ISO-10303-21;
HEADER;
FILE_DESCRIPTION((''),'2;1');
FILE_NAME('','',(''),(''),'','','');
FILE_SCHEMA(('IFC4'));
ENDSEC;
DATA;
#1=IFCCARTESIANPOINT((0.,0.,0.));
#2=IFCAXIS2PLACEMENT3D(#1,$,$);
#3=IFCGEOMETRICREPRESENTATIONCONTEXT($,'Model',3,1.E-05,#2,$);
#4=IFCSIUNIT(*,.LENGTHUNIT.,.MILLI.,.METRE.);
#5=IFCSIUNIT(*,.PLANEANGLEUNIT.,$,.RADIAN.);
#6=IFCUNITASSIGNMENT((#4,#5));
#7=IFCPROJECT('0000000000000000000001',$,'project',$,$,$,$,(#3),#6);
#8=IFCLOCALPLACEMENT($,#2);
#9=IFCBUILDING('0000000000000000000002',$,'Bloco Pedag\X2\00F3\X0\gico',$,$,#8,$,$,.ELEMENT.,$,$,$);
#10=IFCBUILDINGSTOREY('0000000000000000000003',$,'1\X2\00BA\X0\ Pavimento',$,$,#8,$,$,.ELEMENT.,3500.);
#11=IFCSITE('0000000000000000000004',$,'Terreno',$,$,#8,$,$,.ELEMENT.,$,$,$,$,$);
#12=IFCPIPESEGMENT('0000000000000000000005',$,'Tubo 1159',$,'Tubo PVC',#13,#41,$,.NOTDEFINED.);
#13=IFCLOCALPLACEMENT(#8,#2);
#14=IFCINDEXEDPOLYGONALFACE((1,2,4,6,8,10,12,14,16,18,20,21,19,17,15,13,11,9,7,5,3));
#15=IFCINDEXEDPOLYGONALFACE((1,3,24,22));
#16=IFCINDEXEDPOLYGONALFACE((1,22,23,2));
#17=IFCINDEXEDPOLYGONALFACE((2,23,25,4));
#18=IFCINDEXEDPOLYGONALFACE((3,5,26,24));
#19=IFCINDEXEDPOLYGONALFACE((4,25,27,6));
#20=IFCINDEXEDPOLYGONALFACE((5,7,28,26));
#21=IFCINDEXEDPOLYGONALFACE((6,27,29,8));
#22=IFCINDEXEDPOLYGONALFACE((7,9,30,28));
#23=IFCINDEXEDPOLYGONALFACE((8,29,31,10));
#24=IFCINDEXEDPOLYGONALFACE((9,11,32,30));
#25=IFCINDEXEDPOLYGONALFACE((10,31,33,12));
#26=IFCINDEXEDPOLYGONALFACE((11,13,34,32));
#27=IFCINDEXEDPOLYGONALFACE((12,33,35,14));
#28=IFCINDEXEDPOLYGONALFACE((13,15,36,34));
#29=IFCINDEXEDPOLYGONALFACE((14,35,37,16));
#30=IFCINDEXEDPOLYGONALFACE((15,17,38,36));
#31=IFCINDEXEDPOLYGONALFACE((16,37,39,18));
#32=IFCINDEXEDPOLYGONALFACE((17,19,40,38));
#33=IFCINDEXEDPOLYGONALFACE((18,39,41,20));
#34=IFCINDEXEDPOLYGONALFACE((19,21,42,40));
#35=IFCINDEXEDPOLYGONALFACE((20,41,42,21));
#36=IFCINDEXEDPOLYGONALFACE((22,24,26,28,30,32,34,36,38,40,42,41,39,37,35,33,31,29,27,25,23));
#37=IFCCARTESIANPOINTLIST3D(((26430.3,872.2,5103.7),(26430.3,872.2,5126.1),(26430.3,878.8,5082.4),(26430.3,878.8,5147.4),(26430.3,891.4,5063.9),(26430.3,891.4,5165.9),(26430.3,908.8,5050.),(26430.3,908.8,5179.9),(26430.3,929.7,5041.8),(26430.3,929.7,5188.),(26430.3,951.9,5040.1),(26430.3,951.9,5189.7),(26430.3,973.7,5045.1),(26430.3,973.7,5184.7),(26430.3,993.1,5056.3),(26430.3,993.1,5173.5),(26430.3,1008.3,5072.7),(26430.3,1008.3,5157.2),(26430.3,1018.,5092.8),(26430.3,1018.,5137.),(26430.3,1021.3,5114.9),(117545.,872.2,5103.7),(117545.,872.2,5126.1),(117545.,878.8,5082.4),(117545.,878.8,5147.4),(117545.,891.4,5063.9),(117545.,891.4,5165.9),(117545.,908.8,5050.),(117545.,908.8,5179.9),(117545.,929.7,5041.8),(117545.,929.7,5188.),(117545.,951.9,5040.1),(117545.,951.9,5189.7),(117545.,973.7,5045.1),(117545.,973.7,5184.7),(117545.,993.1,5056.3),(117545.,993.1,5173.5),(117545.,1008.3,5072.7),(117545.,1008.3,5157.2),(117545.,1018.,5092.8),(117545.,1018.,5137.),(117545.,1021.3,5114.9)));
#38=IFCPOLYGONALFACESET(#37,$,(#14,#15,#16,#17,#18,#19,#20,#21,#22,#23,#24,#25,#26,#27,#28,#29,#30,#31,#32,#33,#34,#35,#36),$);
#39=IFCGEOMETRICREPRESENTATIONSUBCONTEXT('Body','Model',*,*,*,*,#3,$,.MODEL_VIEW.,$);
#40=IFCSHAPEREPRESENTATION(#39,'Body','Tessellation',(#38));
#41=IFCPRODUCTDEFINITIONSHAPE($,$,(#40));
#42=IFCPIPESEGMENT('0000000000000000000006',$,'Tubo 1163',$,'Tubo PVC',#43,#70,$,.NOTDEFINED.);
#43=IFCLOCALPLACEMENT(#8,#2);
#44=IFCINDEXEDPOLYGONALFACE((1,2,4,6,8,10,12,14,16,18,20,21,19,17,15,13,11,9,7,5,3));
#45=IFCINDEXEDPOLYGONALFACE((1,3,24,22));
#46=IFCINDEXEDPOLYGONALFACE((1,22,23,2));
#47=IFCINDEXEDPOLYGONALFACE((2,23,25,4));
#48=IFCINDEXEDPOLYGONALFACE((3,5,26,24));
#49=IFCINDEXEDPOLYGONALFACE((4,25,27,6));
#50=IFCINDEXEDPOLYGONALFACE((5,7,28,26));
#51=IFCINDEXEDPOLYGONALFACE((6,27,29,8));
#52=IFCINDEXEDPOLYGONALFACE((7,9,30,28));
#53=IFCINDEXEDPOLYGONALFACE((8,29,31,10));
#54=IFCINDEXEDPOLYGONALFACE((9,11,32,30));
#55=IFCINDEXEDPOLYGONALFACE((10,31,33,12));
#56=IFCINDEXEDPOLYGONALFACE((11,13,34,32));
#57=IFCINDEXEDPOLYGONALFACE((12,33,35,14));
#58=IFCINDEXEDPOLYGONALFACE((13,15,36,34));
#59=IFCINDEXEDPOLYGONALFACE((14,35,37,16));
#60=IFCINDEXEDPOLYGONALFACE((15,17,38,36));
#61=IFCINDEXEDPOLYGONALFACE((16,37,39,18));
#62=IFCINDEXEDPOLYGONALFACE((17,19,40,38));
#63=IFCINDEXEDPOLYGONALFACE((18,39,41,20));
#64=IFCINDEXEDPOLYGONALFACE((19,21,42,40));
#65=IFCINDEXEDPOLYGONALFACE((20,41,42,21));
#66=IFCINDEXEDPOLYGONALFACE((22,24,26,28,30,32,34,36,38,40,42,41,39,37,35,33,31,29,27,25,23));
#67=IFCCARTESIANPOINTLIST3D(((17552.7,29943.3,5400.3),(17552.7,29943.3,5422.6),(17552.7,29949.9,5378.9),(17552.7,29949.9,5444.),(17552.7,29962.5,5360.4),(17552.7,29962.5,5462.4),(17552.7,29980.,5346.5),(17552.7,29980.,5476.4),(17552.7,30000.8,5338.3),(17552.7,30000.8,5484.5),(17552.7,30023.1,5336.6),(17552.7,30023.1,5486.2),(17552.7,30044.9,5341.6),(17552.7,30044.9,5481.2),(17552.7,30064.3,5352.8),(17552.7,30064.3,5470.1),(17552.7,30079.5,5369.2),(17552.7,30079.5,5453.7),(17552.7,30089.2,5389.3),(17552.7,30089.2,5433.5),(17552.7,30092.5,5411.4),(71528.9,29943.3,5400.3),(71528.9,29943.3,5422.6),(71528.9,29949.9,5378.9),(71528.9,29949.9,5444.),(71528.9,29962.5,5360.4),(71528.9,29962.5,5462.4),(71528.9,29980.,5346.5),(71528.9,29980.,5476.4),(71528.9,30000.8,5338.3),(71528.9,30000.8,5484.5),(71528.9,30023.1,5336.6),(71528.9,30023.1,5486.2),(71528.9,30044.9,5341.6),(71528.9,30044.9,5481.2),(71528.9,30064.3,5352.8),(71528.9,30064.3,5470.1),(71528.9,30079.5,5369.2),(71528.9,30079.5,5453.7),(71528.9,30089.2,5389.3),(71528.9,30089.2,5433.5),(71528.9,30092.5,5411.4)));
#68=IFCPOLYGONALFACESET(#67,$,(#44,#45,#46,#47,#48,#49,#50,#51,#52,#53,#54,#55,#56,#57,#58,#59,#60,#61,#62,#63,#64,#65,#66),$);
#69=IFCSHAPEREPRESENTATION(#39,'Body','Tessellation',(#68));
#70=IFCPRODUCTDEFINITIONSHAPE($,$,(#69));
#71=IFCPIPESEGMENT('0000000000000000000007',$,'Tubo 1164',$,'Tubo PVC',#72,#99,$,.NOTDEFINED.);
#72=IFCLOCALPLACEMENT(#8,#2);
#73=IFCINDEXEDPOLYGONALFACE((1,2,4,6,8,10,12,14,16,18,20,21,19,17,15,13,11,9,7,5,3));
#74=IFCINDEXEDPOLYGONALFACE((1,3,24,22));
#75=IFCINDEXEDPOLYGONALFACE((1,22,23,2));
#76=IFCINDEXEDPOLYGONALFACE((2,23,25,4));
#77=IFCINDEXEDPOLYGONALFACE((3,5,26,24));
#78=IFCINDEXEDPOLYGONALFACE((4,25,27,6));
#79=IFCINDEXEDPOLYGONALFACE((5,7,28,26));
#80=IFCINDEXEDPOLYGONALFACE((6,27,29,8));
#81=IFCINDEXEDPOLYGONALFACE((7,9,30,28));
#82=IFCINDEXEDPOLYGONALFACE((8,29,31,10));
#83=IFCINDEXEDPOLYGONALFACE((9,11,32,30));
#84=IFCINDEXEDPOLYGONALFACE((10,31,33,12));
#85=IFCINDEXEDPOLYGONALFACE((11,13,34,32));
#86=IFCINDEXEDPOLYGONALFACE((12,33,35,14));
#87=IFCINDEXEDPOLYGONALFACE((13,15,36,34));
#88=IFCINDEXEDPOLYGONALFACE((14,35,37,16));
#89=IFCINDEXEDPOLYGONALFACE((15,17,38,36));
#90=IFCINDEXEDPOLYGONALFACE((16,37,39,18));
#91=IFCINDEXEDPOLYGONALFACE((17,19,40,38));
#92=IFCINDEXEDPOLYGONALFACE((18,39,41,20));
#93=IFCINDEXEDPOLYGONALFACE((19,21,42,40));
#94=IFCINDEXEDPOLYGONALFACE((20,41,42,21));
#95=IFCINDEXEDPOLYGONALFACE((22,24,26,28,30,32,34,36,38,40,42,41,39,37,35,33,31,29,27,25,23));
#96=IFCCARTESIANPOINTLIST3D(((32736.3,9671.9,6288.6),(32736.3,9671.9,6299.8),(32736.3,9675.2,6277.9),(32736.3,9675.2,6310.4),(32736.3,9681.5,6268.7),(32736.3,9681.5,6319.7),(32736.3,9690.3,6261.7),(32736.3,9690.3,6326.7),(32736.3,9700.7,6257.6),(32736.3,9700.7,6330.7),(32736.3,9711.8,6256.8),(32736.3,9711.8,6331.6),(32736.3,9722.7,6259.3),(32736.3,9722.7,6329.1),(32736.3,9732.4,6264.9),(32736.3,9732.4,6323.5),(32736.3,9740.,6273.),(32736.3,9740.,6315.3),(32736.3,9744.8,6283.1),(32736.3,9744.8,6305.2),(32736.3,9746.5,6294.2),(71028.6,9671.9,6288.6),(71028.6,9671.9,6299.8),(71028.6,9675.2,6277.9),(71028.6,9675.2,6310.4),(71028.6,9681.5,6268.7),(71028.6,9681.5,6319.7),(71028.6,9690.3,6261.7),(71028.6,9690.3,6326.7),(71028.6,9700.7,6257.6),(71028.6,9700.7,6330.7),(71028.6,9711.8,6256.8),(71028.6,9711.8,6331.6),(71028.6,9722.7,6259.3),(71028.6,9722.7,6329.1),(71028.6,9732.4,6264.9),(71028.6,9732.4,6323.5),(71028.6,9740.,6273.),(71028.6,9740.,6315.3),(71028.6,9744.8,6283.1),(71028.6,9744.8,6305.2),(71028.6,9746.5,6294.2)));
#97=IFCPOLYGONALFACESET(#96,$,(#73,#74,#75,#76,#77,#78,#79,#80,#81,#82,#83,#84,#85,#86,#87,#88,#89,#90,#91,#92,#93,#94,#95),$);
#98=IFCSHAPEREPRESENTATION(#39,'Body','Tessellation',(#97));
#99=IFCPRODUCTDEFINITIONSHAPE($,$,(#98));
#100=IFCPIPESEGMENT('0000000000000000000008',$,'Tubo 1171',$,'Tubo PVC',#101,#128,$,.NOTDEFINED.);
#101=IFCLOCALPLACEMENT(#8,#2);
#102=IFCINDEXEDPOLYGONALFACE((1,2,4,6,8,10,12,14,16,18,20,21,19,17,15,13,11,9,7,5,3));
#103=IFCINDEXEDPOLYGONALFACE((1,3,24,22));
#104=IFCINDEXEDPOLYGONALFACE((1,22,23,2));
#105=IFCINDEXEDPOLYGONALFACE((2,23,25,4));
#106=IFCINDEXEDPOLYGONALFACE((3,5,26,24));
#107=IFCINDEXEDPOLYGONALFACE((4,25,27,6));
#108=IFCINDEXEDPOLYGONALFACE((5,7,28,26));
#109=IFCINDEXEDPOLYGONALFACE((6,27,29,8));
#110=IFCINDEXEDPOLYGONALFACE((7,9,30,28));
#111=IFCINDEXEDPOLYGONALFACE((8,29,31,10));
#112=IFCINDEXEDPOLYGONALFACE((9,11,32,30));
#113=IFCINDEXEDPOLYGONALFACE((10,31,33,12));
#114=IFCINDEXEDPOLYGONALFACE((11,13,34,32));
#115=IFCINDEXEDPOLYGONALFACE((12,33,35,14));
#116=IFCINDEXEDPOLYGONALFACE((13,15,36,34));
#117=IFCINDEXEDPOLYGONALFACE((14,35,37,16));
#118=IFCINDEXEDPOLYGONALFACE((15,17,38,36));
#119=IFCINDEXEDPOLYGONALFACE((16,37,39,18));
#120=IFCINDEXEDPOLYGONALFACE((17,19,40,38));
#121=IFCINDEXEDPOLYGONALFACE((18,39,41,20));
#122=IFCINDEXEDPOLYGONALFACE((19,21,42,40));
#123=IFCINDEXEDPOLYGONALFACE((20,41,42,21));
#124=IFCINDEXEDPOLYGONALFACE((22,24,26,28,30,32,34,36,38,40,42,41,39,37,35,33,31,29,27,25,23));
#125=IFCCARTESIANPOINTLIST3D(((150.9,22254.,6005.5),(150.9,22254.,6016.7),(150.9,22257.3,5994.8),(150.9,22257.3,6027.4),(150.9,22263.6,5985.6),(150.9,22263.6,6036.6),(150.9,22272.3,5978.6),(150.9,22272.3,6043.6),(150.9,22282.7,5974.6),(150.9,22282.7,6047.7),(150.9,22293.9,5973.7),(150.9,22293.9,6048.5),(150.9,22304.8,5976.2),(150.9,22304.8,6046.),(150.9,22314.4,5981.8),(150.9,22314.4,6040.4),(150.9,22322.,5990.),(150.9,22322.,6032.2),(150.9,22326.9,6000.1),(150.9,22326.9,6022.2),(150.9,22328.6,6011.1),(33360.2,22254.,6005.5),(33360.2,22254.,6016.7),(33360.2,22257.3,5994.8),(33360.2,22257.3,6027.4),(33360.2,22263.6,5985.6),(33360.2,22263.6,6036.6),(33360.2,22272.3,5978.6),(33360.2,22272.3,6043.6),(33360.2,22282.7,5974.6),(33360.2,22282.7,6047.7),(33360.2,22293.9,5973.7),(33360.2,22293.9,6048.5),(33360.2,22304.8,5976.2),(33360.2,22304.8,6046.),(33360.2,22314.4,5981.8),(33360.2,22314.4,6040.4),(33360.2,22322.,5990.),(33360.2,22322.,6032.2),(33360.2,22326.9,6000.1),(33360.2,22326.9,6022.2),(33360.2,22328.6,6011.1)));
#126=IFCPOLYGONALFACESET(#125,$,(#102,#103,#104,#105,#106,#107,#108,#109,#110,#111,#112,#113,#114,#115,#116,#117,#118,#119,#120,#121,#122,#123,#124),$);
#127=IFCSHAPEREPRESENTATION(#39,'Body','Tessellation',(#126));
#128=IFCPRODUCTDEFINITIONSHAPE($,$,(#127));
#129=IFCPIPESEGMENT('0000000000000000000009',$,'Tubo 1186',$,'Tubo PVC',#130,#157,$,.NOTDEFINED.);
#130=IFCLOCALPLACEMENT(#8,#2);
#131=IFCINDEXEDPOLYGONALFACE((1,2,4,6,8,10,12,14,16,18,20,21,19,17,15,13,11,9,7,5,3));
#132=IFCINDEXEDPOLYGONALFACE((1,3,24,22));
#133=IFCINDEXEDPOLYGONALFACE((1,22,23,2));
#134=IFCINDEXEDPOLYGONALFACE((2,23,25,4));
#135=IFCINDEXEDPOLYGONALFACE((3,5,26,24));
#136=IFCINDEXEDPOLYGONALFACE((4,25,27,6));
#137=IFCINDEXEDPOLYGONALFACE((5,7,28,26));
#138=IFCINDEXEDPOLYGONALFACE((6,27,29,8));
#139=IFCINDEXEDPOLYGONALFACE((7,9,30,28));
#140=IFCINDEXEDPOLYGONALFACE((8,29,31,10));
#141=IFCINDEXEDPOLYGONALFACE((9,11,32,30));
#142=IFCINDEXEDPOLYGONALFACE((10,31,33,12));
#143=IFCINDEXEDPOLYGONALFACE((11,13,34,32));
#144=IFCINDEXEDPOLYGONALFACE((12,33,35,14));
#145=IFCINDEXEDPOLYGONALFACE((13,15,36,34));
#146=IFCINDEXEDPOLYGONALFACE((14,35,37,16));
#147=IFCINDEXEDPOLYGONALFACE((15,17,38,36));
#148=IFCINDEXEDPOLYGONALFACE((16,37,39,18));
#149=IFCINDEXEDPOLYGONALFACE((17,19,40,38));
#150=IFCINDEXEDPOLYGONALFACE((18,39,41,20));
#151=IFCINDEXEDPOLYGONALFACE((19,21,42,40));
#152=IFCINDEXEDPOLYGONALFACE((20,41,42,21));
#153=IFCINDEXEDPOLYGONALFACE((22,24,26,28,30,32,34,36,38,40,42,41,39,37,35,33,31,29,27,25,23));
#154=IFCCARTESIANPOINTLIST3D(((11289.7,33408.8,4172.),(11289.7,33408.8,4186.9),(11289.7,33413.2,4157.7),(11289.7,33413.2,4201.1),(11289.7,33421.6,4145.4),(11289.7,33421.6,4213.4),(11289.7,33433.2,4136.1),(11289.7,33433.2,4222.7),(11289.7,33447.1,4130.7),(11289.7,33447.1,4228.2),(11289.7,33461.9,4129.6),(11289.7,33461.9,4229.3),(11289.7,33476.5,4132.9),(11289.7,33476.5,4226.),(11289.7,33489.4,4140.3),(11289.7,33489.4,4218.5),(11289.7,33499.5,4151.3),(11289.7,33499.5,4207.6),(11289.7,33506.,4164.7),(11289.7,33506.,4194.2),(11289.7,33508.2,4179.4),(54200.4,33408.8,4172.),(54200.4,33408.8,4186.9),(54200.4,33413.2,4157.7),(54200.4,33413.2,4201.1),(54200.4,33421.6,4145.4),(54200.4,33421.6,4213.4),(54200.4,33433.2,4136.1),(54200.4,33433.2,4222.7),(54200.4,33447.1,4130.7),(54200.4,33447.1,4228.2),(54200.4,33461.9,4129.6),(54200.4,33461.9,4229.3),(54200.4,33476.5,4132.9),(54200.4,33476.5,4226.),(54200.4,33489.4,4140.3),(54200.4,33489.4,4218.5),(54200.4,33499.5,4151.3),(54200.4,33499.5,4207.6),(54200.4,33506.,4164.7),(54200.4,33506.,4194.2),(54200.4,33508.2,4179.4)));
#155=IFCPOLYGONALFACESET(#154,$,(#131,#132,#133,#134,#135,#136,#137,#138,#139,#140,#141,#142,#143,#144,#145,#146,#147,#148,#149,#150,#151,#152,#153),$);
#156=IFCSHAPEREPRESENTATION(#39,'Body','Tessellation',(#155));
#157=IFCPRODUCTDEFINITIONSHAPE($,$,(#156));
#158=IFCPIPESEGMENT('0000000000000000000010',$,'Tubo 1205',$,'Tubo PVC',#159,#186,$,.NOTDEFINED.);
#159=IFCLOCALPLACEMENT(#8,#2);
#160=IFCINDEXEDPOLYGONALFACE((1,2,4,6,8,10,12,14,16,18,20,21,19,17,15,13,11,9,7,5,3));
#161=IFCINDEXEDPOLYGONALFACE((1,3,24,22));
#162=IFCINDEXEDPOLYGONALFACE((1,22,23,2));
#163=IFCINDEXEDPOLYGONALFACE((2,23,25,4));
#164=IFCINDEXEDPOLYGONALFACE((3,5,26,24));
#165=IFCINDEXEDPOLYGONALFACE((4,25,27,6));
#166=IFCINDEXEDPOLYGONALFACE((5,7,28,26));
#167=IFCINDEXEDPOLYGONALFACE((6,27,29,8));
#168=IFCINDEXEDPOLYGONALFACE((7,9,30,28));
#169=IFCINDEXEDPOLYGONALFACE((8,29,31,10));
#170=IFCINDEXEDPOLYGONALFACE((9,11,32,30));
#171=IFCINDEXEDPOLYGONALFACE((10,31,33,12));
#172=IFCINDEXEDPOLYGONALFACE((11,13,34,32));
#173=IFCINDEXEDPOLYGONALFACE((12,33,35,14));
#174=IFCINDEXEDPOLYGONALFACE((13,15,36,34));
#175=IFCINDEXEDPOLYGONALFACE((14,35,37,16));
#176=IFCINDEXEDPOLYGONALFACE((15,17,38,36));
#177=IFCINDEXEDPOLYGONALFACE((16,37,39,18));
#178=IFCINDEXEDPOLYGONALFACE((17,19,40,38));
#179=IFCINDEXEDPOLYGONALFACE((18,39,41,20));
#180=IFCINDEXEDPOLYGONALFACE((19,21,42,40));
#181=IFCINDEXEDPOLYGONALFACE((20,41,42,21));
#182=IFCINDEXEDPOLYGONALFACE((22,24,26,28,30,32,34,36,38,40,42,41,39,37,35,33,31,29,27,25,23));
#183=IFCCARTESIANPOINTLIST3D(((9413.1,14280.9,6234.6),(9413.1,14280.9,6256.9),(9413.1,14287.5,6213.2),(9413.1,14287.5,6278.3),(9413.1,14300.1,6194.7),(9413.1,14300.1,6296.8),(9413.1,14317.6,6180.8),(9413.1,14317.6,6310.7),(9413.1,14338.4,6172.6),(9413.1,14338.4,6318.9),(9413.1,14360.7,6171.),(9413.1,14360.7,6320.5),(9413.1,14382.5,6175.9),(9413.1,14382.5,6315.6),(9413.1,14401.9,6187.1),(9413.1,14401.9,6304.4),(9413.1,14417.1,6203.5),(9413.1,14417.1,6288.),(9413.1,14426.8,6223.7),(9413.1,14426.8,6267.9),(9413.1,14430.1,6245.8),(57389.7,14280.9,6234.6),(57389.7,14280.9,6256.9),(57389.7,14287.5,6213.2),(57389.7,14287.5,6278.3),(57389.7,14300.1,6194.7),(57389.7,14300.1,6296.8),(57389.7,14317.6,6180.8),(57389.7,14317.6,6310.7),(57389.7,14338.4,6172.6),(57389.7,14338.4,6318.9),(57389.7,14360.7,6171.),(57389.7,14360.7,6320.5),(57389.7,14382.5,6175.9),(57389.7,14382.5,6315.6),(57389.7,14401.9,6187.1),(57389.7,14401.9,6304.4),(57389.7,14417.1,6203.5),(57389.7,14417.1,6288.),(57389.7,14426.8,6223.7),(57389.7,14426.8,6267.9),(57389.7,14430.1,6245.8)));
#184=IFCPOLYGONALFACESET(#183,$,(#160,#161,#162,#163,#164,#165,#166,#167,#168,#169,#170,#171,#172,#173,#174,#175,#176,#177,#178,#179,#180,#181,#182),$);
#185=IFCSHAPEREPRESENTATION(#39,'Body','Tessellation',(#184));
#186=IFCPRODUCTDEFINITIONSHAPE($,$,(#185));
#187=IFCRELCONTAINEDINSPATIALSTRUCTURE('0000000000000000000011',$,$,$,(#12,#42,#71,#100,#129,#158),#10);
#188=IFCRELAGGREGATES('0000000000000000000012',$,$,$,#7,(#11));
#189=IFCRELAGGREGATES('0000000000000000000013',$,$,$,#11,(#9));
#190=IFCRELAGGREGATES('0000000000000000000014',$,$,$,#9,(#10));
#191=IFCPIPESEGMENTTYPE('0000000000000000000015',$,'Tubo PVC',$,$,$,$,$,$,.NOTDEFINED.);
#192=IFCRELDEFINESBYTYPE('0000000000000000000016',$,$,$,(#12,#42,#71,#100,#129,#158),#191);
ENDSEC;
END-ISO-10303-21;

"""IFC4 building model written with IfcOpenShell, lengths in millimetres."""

from ifc_helpers import new_model, si_unit, frame, origin, origin_2d, place, context, subcontext, project, spatial, circle, extrude, type_object, element, save


model = new_model("IFC4")

# Units and contexts
model_context = context("Model", 3, precision=1e-05, world=origin())
body_context = subcontext(model_context, "Body", "Model", "MODEL_VIEW")
ifc_project = project(units=[si_unit("LENGTHUNIT", "METRE", prefix="MILLI"), si_unit("PLANEANGLEUNIT", "RADIAN")], contexts=[model_context])

# Site, building, storey
placement = place(None, origin())
site = spatial("IfcSite", under=ifc_project, at=placement, Name="Terreno", CompositionType="ELEMENT")
building = spatial("IfcBuilding", under=site, at=placement, Name="Bloco Pedagógico", CompositionType="ELEMENT")
storey = spatial("IfcBuildingStorey", under=building, at=placement, Name="1º Pavimento", CompositionType="ELEMENT", Elevation=3500.0)

# Pipe segments
pipe_segment_type = type_object("IfcPipeSegmentType", Name="Tubo PVC", PredefinedType="NOTDEFINED")
pipe_segment_1_placement = place(None, frame((26430.3, 946.3, 5114.9), z_axis=(1.0, 0.0, 0.0), x_axis=(0.0, 1.0, 0.0)))
element("IfcPipeSegment", 1, at=pipe_segment_1_placement, inside=storey, type_object=pipe_segment_type, Name="Tubo 1159", ObjectType="Tubo PVC", PredefinedType="NOTDEFINED", context=body_context, shape_type="SweptSolid", body=[
    extrude(circle(Radius=75.0, at=origin_2d()), None, (0.0, 0.0, 1.0), 91114.8),
])
pipe_segment_2_placement = place(None, frame((17552.7, 30017.5, 5411.4), z_axis=(1.0, 0.0, 0.0), x_axis=(0.0, 1.0, 0.0)))
element("IfcPipeSegment", 2, at=pipe_segment_2_placement, inside=storey, type_object=pipe_segment_type, Name="Tubo 1163", ObjectType="Tubo PVC", PredefinedType="NOTDEFINED", context=body_context, shape_type="SweptSolid", body=[
    extrude(circle(Radius=75.0, at=origin_2d()), None, (0.0, 0.0, 1.0), 53976.2),
])
pipe_segment_3_placement = place(None, frame((32736.3, 9709.0, 6294.2), z_axis=(1.0, 0.0, 0.0), x_axis=(0.0, 1.0, 0.0)))
element("IfcPipeSegment", 3, at=pipe_segment_3_placement, inside=storey, type_object=pipe_segment_type, Name="Tubo 1164", ObjectType="Tubo PVC", PredefinedType="NOTDEFINED", context=body_context, shape_type="SweptSolid", body=[
    extrude(circle(Radius=37.5, at=origin_2d()), None, (0.0, 0.0, 1.0), 38292.3),
])
pipe_segment_4_placement = place(None, frame((150.9, 22291.1, 6011.1), z_axis=(1.0, 0.0, 0.0), x_axis=(0.0, 1.0, 0.0)))
element("IfcPipeSegment", 4, at=pipe_segment_4_placement, inside=storey, type_object=pipe_segment_type, Name="Tubo 1171", ObjectType="Tubo PVC", PredefinedType="NOTDEFINED", context=body_context, shape_type="SweptSolid", body=[
    extrude(circle(Radius=37.5, at=origin_2d()), None, (0.0, 0.0, 1.0), 33209.3),
])
pipe_segment_5_placement = place(None, frame((11289.7, 33458.2, 4179.4), z_axis=(1.0, 0.0, 0.0), x_axis=(0.0, 1.0, 0.0)))
element("IfcPipeSegment", 5, at=pipe_segment_5_placement, inside=storey, type_object=pipe_segment_type, Name="Tubo 1186", ObjectType="Tubo PVC", PredefinedType="NOTDEFINED", context=body_context, shape_type="SweptSolid", body=[
    extrude(circle(Radius=50.0, at=origin_2d()), None, (0.0, 0.0, 1.0), 42910.6),
])
pipe_segment_6_placement = place(None, frame((9413.1, 14355.1, 6245.8), z_axis=(1.0, 0.0, 0.0), x_axis=(0.0, 1.0, 0.0)))
element("IfcPipeSegment", 6, at=pipe_segment_6_placement, inside=storey, type_object=pipe_segment_type, Name="Tubo 1205", ObjectType="Tubo PVC", PredefinedType="NOTDEFINED", context=body_context, shape_type="SweptSolid", body=[
    extrude(circle(Radius=75.0, at=origin_2d()), None, (0.0, 0.0, 1.0), 47976.5),
])

save(model, "model.ifc")
